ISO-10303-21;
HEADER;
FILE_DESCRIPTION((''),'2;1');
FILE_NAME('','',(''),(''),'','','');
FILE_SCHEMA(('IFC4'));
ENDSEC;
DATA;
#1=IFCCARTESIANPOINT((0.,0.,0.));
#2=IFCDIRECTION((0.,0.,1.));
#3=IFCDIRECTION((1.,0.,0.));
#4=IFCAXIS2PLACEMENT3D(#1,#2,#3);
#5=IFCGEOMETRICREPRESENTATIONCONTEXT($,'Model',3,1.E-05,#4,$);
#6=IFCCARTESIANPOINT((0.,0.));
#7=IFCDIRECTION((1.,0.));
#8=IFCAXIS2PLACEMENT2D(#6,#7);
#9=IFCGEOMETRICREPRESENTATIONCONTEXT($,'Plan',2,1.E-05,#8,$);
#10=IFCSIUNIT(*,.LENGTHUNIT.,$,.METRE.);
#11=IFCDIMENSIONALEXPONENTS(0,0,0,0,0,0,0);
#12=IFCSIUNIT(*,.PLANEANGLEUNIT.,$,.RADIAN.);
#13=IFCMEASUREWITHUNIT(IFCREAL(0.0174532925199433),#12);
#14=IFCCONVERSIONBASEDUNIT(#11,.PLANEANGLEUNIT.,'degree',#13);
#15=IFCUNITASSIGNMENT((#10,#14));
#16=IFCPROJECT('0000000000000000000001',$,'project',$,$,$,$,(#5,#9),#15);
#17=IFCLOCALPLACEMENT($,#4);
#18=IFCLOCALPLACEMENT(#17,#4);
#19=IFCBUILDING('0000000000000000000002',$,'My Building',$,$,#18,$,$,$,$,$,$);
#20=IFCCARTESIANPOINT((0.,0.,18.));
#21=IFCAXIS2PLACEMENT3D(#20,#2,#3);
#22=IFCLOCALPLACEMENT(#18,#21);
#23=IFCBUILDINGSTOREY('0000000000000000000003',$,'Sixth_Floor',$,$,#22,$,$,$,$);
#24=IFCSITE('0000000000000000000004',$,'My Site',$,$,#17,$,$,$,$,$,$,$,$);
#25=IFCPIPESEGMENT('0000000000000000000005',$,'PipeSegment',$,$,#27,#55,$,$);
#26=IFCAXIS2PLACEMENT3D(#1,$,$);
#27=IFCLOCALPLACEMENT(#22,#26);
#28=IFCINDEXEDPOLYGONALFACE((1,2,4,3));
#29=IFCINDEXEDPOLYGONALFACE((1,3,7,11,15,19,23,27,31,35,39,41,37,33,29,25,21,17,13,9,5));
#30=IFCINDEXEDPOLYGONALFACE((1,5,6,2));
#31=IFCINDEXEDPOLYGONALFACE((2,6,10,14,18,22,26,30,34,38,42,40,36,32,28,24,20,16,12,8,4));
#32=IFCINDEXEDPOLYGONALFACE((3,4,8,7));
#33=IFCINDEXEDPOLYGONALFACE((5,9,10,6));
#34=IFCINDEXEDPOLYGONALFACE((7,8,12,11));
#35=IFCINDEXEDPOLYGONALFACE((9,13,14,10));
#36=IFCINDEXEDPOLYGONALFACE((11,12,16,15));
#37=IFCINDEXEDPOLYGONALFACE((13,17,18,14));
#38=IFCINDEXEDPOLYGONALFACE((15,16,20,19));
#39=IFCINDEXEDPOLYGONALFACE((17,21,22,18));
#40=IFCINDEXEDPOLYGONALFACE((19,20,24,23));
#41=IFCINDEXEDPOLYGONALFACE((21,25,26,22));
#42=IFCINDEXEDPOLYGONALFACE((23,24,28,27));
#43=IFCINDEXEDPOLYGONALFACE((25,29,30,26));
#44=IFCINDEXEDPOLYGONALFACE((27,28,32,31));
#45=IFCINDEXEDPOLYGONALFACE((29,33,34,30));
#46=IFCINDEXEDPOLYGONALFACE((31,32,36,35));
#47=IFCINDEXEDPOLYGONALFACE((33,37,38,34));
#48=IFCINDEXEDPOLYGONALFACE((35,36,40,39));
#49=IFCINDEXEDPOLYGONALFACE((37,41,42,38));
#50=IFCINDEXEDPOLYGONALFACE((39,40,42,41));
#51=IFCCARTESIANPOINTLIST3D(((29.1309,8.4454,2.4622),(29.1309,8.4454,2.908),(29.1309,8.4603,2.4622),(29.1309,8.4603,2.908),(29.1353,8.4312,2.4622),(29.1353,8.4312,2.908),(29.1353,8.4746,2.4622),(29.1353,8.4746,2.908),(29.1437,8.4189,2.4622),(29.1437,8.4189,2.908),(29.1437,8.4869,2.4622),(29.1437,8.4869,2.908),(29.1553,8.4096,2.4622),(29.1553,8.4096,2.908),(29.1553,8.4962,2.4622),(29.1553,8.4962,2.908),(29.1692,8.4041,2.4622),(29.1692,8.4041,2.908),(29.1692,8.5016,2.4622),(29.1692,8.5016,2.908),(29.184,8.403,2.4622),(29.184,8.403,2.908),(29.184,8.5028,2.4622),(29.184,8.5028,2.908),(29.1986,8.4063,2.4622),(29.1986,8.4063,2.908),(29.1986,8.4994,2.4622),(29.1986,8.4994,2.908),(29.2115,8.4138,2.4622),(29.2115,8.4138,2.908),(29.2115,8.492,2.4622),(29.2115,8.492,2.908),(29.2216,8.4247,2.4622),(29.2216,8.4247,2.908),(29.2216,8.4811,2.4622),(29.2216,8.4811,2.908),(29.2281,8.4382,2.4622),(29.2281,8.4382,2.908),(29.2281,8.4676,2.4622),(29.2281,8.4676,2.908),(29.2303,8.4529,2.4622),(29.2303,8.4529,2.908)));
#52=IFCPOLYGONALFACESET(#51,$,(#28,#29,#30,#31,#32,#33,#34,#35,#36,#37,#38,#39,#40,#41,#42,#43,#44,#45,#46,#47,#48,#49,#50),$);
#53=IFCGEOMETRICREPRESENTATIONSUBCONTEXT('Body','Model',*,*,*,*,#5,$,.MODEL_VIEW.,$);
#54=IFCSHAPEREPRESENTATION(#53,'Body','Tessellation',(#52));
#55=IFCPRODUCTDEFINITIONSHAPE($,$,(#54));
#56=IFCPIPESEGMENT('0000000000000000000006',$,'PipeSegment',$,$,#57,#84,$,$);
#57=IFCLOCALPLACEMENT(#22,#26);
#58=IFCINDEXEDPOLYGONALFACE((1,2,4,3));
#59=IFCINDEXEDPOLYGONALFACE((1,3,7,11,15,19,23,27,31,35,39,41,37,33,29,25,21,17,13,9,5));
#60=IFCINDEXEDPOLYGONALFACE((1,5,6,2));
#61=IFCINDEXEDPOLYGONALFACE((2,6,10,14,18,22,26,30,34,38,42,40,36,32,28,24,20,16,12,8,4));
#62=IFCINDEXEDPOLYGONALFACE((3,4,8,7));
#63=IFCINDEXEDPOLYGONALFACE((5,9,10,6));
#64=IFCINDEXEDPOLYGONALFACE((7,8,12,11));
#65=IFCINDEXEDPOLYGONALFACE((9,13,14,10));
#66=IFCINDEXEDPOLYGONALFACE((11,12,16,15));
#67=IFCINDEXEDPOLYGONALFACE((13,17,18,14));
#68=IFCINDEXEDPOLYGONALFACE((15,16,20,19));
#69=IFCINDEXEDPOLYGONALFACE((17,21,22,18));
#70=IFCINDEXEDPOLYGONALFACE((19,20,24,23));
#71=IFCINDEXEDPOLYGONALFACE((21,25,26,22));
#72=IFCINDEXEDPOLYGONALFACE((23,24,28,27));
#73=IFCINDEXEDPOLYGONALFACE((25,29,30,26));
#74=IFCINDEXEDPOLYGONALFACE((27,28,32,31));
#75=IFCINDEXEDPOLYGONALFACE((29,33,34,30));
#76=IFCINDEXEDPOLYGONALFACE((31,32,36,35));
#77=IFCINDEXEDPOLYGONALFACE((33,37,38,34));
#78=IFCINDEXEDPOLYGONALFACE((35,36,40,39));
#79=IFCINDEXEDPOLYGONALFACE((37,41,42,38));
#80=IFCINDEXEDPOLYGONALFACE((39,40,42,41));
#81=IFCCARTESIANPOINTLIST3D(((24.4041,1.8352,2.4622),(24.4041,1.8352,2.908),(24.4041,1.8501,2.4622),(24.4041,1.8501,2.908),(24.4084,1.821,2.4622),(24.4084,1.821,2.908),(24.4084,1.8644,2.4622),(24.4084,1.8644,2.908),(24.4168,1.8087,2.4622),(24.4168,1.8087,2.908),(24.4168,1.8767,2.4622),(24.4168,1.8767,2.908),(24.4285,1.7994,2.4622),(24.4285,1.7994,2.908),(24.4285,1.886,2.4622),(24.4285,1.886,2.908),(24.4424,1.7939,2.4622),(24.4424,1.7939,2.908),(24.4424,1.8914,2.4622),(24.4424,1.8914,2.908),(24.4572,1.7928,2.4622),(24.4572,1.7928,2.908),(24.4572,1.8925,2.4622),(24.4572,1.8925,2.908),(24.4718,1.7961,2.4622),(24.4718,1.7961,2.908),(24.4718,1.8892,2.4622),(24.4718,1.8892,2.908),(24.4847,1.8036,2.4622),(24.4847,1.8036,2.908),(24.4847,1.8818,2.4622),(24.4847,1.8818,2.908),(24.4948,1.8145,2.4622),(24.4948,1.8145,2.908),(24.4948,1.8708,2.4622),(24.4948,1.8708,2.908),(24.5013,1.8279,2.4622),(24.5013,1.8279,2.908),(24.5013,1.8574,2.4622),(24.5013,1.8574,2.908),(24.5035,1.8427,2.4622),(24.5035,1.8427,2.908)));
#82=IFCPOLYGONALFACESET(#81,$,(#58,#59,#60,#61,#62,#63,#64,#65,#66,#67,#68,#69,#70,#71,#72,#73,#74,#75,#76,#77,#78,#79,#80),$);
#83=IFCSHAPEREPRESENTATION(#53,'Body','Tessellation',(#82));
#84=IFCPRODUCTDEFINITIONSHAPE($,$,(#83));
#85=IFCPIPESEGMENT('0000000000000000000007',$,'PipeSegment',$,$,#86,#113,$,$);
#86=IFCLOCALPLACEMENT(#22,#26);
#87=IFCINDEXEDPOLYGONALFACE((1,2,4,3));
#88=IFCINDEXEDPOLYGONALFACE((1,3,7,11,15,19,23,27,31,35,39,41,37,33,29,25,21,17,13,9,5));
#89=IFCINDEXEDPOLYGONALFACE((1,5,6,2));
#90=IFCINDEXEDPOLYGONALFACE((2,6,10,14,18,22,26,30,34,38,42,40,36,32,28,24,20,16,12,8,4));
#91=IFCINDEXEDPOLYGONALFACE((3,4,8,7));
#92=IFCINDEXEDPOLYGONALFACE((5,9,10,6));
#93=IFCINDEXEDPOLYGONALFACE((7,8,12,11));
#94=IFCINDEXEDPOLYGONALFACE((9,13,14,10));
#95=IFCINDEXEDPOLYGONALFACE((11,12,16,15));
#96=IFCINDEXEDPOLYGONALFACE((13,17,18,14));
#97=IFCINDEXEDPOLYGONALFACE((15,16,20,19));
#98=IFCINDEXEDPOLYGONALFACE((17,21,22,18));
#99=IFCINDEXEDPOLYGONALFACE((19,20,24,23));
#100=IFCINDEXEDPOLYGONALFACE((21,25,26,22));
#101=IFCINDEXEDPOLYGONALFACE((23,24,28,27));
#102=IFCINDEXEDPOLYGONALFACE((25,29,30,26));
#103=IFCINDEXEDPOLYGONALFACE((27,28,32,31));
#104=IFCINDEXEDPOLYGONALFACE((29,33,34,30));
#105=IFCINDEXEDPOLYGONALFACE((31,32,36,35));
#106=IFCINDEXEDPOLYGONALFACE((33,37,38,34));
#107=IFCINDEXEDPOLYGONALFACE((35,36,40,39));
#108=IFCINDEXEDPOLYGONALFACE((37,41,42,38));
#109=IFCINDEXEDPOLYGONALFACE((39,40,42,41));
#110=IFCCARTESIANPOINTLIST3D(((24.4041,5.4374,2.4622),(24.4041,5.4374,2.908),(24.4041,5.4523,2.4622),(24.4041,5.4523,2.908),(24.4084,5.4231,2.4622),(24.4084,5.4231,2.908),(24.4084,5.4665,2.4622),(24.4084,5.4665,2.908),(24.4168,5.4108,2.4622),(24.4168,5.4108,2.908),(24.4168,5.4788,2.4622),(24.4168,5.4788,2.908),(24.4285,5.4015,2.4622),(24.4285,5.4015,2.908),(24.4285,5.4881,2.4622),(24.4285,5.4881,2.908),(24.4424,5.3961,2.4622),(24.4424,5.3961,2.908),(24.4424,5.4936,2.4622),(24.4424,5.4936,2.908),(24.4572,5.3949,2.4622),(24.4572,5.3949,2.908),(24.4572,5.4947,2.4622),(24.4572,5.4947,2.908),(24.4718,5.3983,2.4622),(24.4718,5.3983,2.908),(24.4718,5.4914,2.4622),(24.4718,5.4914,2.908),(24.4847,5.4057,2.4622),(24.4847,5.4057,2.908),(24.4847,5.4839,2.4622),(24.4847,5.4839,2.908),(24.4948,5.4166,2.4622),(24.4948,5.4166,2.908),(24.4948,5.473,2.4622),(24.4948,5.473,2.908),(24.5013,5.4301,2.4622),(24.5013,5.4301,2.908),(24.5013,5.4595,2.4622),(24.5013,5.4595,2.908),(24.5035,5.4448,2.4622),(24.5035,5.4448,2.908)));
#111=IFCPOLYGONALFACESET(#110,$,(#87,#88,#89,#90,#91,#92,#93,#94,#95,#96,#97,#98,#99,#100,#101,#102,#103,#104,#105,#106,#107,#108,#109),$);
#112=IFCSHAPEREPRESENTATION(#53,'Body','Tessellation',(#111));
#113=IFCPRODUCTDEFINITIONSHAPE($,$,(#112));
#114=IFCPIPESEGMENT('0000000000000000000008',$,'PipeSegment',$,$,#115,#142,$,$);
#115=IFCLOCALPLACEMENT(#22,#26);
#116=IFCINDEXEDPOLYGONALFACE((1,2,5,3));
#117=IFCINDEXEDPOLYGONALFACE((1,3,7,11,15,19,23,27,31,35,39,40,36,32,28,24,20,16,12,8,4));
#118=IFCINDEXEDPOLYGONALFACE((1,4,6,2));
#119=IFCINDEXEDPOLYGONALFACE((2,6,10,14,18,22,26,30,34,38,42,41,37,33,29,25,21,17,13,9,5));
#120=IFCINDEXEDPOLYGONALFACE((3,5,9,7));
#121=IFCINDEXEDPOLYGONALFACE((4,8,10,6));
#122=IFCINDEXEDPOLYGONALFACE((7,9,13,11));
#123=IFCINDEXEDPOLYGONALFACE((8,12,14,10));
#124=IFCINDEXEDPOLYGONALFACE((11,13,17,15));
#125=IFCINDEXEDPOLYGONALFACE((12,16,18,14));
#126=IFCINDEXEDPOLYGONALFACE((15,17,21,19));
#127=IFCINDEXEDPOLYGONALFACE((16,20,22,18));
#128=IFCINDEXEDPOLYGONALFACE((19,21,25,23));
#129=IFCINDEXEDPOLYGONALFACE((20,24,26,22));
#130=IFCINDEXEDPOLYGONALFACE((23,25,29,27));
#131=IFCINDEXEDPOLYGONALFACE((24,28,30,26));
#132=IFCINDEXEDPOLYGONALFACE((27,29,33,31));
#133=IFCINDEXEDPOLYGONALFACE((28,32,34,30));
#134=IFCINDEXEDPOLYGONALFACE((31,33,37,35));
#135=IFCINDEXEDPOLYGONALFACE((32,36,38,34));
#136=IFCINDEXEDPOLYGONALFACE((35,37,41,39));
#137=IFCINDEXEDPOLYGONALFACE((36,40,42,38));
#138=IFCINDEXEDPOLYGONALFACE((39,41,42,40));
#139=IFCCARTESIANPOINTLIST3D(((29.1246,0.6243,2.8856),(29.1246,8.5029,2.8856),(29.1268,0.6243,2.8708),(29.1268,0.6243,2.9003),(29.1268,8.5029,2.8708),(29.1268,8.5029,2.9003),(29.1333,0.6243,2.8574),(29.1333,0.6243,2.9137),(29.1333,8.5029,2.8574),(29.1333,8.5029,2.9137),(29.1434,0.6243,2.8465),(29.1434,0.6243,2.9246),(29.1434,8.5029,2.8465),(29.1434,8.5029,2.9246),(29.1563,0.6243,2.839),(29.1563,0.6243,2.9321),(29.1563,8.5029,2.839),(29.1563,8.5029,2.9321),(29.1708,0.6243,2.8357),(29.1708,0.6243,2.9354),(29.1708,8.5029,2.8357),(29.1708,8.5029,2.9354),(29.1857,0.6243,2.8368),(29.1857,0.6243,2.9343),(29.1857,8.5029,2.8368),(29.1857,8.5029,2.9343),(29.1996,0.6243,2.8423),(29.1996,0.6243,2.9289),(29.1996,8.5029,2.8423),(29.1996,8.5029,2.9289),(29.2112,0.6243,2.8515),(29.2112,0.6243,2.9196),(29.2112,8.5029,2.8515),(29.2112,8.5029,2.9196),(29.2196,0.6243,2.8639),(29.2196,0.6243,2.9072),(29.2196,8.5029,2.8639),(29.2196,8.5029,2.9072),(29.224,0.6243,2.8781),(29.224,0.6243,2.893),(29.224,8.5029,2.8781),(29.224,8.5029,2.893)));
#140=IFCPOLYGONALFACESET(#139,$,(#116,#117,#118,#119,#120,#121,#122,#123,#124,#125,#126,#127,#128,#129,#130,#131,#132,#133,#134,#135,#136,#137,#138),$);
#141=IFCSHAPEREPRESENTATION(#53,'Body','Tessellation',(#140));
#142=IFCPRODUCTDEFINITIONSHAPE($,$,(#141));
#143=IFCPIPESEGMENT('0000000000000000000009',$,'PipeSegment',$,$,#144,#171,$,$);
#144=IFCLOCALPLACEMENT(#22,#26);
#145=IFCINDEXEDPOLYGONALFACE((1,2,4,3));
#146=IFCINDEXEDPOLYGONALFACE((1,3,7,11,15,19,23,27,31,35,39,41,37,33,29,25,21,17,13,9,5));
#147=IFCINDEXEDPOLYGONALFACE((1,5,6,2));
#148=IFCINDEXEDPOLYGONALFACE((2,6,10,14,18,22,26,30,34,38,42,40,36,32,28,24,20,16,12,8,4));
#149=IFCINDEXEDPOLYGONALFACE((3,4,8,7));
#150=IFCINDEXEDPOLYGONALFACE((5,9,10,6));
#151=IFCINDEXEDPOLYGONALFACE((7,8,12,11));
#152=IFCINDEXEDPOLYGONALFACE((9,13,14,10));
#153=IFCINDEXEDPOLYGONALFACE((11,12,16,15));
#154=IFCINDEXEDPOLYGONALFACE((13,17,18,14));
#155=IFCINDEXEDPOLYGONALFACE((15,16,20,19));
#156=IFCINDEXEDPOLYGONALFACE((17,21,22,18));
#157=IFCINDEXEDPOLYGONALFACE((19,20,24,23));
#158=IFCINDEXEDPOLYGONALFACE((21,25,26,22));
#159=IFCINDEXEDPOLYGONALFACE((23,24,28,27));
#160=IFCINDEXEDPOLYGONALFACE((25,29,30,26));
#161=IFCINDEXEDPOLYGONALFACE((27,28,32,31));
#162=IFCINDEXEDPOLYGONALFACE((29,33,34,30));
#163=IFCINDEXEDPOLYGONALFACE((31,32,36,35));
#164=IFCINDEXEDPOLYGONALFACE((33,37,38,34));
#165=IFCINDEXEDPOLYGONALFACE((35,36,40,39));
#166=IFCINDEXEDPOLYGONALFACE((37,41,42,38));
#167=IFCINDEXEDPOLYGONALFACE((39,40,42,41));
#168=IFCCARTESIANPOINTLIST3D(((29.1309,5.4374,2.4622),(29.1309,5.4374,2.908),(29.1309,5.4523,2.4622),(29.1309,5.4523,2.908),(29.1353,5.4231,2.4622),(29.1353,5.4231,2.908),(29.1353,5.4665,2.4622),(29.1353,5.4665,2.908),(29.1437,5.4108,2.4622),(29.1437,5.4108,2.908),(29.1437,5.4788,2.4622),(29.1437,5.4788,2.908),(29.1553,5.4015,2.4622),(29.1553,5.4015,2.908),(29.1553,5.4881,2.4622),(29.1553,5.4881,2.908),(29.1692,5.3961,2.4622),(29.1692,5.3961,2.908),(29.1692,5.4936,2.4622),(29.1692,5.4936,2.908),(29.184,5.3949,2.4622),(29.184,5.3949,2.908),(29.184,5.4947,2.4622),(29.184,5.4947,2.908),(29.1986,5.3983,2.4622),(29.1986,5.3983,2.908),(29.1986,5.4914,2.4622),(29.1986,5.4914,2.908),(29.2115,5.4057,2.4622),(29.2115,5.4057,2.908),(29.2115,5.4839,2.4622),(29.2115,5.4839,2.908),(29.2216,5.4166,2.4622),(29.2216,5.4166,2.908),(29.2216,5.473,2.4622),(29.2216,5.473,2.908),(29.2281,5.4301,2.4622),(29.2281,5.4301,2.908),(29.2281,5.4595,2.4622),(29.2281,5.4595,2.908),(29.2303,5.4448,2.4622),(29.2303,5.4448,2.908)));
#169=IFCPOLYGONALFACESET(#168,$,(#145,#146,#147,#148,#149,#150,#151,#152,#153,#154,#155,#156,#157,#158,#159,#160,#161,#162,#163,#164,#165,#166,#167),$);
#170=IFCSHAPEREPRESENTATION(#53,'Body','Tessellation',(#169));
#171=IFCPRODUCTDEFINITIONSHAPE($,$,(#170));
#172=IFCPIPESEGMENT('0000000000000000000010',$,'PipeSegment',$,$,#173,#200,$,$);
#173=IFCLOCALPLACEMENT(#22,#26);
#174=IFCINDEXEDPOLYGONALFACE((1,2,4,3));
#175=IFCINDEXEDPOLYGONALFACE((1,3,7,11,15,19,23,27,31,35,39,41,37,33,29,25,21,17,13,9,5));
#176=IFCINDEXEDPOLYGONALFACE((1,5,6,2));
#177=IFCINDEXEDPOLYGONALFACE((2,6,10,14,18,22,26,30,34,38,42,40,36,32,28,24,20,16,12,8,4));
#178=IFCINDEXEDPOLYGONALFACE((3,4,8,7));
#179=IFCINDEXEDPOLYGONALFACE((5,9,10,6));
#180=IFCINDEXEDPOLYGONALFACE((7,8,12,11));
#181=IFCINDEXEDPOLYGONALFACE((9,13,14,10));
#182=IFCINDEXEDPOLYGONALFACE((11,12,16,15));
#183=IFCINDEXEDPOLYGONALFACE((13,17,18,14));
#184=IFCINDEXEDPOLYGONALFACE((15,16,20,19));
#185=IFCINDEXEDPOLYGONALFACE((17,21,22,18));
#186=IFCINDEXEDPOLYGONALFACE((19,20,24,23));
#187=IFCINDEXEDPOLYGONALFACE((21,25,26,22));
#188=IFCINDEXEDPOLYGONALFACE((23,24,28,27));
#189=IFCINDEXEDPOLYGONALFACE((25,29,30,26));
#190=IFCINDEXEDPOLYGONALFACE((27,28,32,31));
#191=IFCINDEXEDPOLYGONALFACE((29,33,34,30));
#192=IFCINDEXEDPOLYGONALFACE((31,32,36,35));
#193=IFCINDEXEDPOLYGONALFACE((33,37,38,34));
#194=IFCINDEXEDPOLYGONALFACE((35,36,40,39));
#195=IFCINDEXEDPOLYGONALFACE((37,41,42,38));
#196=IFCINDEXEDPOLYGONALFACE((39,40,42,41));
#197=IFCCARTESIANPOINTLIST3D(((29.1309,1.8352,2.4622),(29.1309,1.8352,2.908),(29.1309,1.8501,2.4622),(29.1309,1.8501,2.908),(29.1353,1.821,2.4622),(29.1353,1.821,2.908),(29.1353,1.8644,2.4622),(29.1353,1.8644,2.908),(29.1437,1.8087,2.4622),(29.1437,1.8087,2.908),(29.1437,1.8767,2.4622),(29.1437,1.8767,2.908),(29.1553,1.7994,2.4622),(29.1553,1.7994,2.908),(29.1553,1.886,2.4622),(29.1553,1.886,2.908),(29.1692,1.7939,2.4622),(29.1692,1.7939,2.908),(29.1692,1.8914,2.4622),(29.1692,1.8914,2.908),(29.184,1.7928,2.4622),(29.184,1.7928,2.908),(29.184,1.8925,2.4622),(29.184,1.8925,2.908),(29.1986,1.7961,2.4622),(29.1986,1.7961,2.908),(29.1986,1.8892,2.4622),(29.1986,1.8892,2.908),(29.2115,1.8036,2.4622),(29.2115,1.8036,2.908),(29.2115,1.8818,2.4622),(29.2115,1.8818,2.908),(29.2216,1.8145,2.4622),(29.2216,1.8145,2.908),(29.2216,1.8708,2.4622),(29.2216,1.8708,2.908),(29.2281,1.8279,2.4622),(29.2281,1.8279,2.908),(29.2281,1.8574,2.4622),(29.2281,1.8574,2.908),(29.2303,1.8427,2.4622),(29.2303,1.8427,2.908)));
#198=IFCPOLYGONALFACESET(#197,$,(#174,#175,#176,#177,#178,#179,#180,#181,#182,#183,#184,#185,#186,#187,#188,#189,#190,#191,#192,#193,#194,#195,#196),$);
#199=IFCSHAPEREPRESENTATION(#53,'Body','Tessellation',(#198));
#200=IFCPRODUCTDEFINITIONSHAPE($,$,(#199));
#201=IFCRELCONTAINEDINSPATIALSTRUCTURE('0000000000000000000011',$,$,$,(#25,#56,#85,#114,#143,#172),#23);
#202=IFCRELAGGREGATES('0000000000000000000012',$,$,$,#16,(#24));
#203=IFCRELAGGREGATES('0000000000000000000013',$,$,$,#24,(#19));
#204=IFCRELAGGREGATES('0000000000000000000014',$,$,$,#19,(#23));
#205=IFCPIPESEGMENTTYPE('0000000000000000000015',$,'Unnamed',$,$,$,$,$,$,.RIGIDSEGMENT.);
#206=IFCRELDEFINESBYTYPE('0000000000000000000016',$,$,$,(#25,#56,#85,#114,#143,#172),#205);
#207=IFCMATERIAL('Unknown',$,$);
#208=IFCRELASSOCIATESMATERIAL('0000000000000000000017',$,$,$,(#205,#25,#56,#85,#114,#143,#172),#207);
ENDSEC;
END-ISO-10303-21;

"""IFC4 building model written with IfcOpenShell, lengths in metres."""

from ifc_helpers import new_model, entity, si_unit, converted_unit, frame, origin_with_axes, origin_2d_with_axis, place, context, subcontext, project, spatial, circle, extrude, material, material_profile, profile_set, profile_usage, type_object, element, save


model = new_model("IFC4")

# Units and contexts
model_context = context("Model", 3, precision=1e-05, world=origin_with_axes())
plan_context = context("Plan", 2, precision=1e-05, world=origin_2d_with_axis())
body_context = subcontext(model_context, "Body", "Model", "MODEL_VIEW")
ifc_project = project(units=[si_unit("LENGTHUNIT", "METRE"), converted_unit("PLANEANGLEUNIT", "degree", entity("IfcReal", 0.0174532925199433), si_unit("PLANEANGLEUNIT", "RADIAN"), dimensions=[0, 0, 0, 0, 0, 0, 0])], contexts=[model_context, plan_context])

# Site, building, storey
site_placement = place(None, origin_with_axes())
site = spatial("IfcSite", under=ifc_project, at=site_placement, Name="My Site")
building_placement = place(site_placement, origin_with_axes())
building = spatial("IfcBuilding", under=site, at=building_placement, Name="My Building")
storey_placement = place(building_placement, frame((0.0, 0.0, 18.0), z_axis=(0.0, 0.0, 1.0), x_axis=(1.0, 0.0, 0.0)))
storey = spatial("IfcBuildingStorey", under=building, at=storey_placement, Name="Sixth_Floor")

# Shared definitions
ifc_material = material(Name="Unknown")

# Pipe segments
ifc_material_profile_1 = material_profile(ifc_material, circle(Radius=0.05))
ifc_profile_set_1 = profile_set([ifc_material_profile_1])
pipe_segment_type = type_object("IfcPipeSegmentType", Name="Unnamed", PredefinedType="RIGIDSEGMENT", material=ifc_profile_set_1)
ifc_profile_usage_1 = profile_usage(ifc_profile_set_1, cardinal=5)
pipe_segment_1_placement = place(storey_placement, frame((29.1803, 8.4529, 2.908), z_axis=(0.0, 0.0, -1.0), x_axis=(1.0, 0.0, 0.0)))
element("IfcPipeSegment", 1, at=pipe_segment_1_placement, inside=storey, type_object=pipe_segment_type, material=ifc_profile_usage_1, Name="PipeSegment", context=body_context, shape_type="SweptSolid", body=[
    extrude(circle(Radius=0.05), origin_with_axes(), (0.0, 0.0, 1.0), 0.4458),
])
ifc_profile_usage_2 = profile_usage(ifc_profile_set_1, cardinal=5)
pipe_segment_2_placement = place(storey_placement, frame((24.4535, 1.8427, 2.908), z_axis=(0.0, 0.0, -1.0), x_axis=(1.0, 0.0, 0.0)))
element("IfcPipeSegment", 2, at=pipe_segment_2_placement, inside=storey, type_object=pipe_segment_type, material=ifc_profile_usage_2, Name="PipeSegment", context=body_context, shape_type="SweptSolid", body=[
    extrude(circle(Radius=0.05), origin_with_axes(), (0.0, 0.0, 1.0), 0.4458),
])
ifc_profile_usage_3 = profile_usage(ifc_profile_set_1, cardinal=5)
pipe_segment_3_placement = place(storey_placement, frame((24.4535, 5.4448, 2.908), z_axis=(0.0, 0.0, -1.0), x_axis=(1.0, 0.0, 0.0)))
element("IfcPipeSegment", 3, at=pipe_segment_3_placement, inside=storey, type_object=pipe_segment_type, material=ifc_profile_usage_3, Name="PipeSegment", context=body_context, shape_type="SweptSolid", body=[
    extrude(circle(Radius=0.05), origin_with_axes(), (0.0, 0.0, 1.0), 0.4458),
])
ifc_profile_usage_4 = profile_usage(ifc_profile_set_1, cardinal=5)
pipe_segment_4_placement = place(storey_placement, frame((29.1746, 0.6243, 2.8856), z_axis=(0.0, 1.0, 0.0), x_axis=(-1.0, 0.0, 0.0)))
element("IfcPipeSegment", 4, at=pipe_segment_4_placement, inside=storey, type_object=pipe_segment_type, material=ifc_profile_usage_4, Name="PipeSegment", context=body_context, shape_type="SweptSolid", body=[
    extrude(circle(Radius=0.05), origin_with_axes(), (0.0, 0.0, 1.0), 7.8786),
])
ifc_profile_usage_5 = profile_usage(ifc_profile_set_1, cardinal=5)
pipe_segment_5_placement = place(storey_placement, frame((29.1803, 5.4448, 2.908), z_axis=(0.0, 0.0, -1.0), x_axis=(1.0, 0.0, 0.0)))
element("IfcPipeSegment", 5, at=pipe_segment_5_placement, inside=storey, type_object=pipe_segment_type, material=ifc_profile_usage_5, Name="PipeSegment", context=body_context, shape_type="SweptSolid", body=[
    extrude(circle(Radius=0.05), origin_with_axes(), (0.0, 0.0, 1.0), 0.4458),
])
ifc_profile_usage_6 = profile_usage(ifc_profile_set_1, cardinal=5)
pipe_segment_6_placement = place(storey_placement, frame((29.1803, 1.8427, 2.908), z_axis=(0.0, 0.0, -1.0), x_axis=(1.0, 0.0, 0.0)))
element("IfcPipeSegment", 6, at=pipe_segment_6_placement, inside=storey, type_object=pipe_segment_type, material=ifc_profile_usage_6, Name="PipeSegment", context=body_context, shape_type="SweptSolid", body=[
    extrude(circle(Radius=0.05), origin_with_axes(), (0.0, 0.0, 1.0), 0.4458),
])

save(model, "model.ifc")
